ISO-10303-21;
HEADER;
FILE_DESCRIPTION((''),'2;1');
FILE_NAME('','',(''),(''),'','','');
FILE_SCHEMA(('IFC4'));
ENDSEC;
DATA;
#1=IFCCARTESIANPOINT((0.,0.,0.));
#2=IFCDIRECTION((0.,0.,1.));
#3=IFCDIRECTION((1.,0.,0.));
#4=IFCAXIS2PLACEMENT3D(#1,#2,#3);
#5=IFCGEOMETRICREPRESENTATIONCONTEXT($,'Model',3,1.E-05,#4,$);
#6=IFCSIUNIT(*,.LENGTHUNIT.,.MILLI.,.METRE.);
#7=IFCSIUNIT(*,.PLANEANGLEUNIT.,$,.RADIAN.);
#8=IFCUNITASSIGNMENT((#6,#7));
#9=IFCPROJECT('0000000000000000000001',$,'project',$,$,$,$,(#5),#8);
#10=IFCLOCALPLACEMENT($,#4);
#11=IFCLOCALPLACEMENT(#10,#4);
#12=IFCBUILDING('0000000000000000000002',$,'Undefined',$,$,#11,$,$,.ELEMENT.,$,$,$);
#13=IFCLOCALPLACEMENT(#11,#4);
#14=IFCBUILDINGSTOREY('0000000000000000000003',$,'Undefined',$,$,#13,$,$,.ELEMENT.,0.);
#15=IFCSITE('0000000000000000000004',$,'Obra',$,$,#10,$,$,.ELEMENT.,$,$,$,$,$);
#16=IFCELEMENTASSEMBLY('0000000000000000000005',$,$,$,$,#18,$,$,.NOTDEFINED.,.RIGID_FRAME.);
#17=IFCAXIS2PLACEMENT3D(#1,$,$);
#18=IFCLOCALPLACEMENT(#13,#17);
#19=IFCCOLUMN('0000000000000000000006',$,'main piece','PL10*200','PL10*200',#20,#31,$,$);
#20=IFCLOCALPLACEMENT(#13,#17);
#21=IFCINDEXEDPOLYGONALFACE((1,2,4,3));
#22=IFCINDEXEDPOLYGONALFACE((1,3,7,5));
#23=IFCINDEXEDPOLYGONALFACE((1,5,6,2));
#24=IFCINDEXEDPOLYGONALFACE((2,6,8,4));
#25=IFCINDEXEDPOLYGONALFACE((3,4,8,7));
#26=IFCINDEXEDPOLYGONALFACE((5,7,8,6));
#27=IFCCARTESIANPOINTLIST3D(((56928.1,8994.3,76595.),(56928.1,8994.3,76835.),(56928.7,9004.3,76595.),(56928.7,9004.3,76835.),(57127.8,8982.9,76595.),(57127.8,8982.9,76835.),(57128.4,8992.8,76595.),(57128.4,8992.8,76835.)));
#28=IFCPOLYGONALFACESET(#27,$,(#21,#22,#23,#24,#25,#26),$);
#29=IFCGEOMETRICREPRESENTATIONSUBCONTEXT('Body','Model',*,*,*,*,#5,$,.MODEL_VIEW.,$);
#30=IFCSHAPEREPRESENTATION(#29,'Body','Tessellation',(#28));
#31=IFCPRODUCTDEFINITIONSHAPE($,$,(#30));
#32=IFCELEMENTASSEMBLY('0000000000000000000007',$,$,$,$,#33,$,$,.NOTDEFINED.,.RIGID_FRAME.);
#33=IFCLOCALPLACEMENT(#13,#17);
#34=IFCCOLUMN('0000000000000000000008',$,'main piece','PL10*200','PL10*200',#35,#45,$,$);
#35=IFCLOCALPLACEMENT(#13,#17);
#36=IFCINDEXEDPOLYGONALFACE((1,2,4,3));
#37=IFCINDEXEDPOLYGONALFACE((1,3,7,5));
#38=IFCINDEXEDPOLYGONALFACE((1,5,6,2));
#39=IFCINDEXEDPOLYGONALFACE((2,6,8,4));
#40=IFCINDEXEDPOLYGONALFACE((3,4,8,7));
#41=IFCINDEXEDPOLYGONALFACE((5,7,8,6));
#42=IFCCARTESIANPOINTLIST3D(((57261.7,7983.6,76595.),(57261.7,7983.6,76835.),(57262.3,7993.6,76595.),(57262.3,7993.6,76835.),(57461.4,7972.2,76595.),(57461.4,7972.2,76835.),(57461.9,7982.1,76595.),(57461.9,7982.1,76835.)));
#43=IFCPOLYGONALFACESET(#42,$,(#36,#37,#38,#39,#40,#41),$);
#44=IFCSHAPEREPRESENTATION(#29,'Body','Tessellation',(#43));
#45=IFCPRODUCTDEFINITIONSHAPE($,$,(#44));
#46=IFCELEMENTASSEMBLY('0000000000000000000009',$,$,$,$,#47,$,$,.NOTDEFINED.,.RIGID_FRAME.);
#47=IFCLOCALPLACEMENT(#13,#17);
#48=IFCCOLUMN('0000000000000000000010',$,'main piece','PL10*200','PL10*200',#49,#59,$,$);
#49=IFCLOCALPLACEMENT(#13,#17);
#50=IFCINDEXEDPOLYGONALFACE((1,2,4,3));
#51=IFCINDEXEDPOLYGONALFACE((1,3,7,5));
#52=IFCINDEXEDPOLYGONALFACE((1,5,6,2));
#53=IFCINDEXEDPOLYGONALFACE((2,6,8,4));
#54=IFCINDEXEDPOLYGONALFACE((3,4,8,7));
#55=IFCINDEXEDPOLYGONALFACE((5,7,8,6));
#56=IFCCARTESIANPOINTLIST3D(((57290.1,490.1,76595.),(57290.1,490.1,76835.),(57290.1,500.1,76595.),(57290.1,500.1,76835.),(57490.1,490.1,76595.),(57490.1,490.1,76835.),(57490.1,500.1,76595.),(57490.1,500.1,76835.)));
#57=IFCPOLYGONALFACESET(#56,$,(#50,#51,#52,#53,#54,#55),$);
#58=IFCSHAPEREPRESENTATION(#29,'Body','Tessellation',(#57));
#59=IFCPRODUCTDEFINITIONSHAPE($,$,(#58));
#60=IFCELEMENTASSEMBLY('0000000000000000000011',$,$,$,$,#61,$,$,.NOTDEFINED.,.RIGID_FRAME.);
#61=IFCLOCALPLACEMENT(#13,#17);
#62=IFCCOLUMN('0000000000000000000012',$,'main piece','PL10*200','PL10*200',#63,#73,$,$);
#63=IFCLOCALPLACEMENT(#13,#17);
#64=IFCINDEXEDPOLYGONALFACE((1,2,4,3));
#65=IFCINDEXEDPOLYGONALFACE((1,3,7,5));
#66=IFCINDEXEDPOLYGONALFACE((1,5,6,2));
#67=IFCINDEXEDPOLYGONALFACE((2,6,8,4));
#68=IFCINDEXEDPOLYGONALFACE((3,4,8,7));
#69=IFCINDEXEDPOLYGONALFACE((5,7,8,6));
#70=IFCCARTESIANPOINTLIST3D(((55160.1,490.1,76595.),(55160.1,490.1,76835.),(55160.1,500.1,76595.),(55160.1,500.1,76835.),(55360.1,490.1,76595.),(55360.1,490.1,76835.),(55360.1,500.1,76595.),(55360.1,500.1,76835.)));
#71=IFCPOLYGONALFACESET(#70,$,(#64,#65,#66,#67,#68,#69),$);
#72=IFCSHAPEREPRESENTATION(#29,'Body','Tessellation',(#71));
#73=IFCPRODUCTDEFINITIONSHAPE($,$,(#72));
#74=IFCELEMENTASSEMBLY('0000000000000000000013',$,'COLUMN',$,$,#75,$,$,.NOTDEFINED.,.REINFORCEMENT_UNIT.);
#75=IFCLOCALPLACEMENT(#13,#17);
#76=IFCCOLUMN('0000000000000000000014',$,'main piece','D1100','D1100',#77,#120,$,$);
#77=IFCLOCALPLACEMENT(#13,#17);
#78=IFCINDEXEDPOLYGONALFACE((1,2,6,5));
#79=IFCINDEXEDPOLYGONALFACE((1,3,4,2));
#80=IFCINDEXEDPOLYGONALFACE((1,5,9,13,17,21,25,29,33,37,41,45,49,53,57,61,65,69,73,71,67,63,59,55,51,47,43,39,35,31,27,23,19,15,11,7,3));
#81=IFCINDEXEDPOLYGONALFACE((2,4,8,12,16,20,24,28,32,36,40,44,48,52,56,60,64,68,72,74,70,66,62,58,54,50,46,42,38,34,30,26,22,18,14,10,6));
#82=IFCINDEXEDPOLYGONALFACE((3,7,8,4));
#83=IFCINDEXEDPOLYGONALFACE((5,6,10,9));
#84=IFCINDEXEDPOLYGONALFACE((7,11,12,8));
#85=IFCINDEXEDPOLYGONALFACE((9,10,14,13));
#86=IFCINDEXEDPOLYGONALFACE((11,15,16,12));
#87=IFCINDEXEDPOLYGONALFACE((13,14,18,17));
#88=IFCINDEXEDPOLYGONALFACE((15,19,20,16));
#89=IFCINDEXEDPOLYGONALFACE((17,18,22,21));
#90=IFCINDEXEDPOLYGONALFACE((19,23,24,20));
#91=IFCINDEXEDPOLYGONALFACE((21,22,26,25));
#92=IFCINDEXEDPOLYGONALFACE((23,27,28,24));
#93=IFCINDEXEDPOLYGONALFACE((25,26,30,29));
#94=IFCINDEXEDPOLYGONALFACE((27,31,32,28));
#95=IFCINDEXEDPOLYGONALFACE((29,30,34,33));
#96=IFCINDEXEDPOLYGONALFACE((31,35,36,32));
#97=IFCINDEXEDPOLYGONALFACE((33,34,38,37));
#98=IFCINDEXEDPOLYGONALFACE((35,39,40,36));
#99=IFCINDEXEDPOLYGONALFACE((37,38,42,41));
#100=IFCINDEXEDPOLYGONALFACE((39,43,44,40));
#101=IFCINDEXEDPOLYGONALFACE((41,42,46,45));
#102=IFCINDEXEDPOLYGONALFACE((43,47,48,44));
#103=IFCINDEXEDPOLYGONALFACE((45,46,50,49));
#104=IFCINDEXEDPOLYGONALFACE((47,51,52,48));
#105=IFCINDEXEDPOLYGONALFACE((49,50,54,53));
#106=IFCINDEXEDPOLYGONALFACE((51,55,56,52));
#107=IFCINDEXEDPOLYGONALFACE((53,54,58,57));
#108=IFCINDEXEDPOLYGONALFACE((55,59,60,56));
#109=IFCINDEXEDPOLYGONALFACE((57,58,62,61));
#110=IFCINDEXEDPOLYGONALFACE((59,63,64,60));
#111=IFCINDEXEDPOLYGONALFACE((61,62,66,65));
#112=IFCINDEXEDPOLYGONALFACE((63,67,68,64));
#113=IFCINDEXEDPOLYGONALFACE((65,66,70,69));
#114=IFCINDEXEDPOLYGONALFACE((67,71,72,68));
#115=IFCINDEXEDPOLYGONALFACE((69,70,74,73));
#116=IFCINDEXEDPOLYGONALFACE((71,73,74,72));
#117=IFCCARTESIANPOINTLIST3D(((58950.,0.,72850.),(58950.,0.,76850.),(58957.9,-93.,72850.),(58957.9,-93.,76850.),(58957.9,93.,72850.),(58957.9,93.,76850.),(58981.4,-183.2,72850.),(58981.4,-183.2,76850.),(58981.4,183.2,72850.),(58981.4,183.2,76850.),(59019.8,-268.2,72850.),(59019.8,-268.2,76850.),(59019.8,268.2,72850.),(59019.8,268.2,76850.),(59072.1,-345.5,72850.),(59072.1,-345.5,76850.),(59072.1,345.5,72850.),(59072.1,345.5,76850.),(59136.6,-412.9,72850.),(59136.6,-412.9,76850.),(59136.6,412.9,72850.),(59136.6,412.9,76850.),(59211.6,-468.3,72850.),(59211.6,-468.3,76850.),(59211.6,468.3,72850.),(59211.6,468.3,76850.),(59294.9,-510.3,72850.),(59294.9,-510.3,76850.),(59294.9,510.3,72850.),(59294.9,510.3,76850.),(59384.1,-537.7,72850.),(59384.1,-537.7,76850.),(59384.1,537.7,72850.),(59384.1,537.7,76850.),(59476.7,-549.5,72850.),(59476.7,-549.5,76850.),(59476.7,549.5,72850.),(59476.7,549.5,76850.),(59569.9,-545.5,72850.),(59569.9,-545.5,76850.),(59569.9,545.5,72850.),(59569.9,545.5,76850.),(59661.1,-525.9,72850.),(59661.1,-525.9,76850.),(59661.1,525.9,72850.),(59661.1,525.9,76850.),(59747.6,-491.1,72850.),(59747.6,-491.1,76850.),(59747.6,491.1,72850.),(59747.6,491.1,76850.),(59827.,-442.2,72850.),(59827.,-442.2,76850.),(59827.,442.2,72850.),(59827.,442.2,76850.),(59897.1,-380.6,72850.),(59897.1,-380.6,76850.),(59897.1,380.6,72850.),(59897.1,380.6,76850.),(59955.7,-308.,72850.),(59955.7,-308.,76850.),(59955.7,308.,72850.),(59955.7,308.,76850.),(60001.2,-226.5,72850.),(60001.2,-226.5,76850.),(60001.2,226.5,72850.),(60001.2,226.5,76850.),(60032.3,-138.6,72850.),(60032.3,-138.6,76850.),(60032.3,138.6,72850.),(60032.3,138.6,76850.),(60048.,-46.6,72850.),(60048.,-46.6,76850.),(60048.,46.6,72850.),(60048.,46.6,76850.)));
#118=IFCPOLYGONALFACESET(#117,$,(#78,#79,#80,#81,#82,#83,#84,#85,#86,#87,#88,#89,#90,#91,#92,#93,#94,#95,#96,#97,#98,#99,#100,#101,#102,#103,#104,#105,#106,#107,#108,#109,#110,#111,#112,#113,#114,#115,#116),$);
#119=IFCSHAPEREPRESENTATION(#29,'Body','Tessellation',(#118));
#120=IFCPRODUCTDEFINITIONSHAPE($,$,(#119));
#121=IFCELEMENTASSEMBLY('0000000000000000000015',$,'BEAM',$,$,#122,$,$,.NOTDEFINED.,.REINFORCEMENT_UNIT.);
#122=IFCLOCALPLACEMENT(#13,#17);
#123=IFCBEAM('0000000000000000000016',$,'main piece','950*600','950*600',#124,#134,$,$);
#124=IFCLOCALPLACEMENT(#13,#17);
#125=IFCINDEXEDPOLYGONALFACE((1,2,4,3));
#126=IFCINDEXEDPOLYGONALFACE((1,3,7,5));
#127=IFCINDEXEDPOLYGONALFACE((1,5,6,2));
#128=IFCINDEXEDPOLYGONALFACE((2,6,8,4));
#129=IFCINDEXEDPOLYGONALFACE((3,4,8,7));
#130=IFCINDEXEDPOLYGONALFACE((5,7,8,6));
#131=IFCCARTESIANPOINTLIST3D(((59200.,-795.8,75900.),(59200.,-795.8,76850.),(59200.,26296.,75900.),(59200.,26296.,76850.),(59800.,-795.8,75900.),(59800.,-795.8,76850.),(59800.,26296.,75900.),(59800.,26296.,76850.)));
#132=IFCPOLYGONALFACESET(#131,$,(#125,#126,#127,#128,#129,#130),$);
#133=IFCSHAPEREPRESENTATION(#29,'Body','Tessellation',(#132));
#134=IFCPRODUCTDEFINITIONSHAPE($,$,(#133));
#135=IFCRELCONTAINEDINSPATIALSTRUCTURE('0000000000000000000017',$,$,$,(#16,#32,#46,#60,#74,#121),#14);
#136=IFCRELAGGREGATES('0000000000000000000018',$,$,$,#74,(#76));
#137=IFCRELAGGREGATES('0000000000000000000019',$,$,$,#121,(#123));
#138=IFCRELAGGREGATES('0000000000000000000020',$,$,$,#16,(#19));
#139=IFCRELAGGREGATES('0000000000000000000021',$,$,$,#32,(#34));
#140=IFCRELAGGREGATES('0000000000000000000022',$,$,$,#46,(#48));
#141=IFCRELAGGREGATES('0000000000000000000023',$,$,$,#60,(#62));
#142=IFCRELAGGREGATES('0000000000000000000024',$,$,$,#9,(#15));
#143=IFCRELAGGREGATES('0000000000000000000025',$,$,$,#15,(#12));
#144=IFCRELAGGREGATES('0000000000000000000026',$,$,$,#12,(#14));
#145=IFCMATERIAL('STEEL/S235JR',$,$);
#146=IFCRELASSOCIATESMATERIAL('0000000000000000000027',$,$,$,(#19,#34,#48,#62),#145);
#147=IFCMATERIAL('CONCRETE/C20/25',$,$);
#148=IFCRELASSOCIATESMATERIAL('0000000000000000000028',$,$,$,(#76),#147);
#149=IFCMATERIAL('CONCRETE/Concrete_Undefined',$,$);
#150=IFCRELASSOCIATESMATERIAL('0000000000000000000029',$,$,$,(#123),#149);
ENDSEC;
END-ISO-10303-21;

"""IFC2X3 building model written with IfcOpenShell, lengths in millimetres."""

from ifc_helpers import new_model, si_unit, frame, origin_with_axes, origin_2d_with_axis, place, context, subcontext, project, spatial, rectangle, circle, extrude, material, element, aggregate, save


model = new_model("IFC2X3")

# Units and contexts
model_context = context("Model", 3, precision=1e-05, world=origin_with_axes())
body_context = subcontext(model_context, "Body", "Model", "MODEL_VIEW")
ifc_project = project(units=[si_unit("LENGTHUNIT", "METRE", prefix="MILLI"), si_unit("PLANEANGLEUNIT", "RADIAN")], contexts=[model_context])

# Site, building, storey
site_placement = place(None, origin_with_axes())
site = spatial("IfcSite", under=ifc_project, at=site_placement, Name="Obra", CompositionType="ELEMENT")
building_placement = place(site_placement, origin_with_axes())
building = spatial("IfcBuilding", under=site, at=building_placement, Name="Undefined", CompositionType="ELEMENT")
storey_placement = place(building_placement, origin_with_axes())
storey = spatial("IfcBuildingStorey", under=building, at=storey_placement, Name="Undefined", CompositionType="ELEMENT", Elevation=0.0)

# Element assemblies, columns
assembly_1_placement = place(storey_placement, origin_with_axes())
assembly_1 = element("IfcElementAssembly", 1, at=assembly_1_placement, inside=storey, AssemblyPlace="NOTDEFINED", PredefinedType="RIGID_FRAME")
ifc_material_1 = material(Name="STEEL/S235JR")
column_1_placement = place(assembly_1_placement, frame((57028.3, 8993.6, 76595.0), z_axis=(0.0, 0.0, 1.0), x_axis=(0.998368, -0.05711, 0.0)))
column_1 = element("IfcColumn", 2, at=column_1_placement, material=ifc_material_1, Name="main piece", Description="PL10*200", ObjectType="PL10*200", context=body_context, shape_type="SweptSolid", body=[
    extrude(rectangle(XDim=10.0, YDim=200.0, at=origin_2d_with_axis()), frame((0.0, 0.0, 240.0), z_axis=(0.0, 0.0, -1.0), x_axis=(0.0, 1.0, 0.0)), (0.0, 0.0, 1.0), 240.0),
])
assembly_2_placement = place(storey_placement, origin_with_axes())
assembly_2 = element("IfcElementAssembly", 3, at=assembly_2_placement, inside=storey, AssemblyPlace="NOTDEFINED", PredefinedType="RIGID_FRAME")
column_2_placement = place(assembly_2_placement, frame((57361.8, 7982.9, 76595.0), z_axis=(0.0, 0.0, 1.0), x_axis=(-0.998368, 0.05711, 0.0)))
column_2 = element("IfcColumn", 4, at=column_2_placement, material=ifc_material_1, Name="main piece", Description="PL10*200", ObjectType="PL10*200", context=body_context, shape_type="SweptSolid", body=[
    extrude(rectangle(XDim=10.0, YDim=200.0, at=origin_2d_with_axis()), frame((0.0, 0.0, 240.0), z_axis=(0.0, 0.0, -1.0), x_axis=(0.0, 1.0, 0.0)), (0.0, 0.0, 1.0), 240.0),
])
assembly_3_placement = place(storey_placement, origin_with_axes())
assembly_3 = element("IfcElementAssembly", 5, at=assembly_3_placement, inside=storey, AssemblyPlace="NOTDEFINED", PredefinedType="RIGID_FRAME")
column_3_placement = place(assembly_3_placement, frame((57390.1, 495.1, 76595.0), z_axis=(0.0, 0.0, 1.0), x_axis=(1.0, 0.000002, 0.0)))
column_3 = element("IfcColumn", 6, at=column_3_placement, material=ifc_material_1, Name="main piece", Description="PL10*200", ObjectType="PL10*200", context=body_context, shape_type="SweptSolid", body=[
    extrude(rectangle(XDim=10.0, YDim=200.0, at=origin_2d_with_axis()), frame((0.0, 0.0, 240.0), z_axis=(0.0, 0.0, -1.0), x_axis=(0.0, 1.0, 0.0)), (0.0, 0.0, 1.0), 240.0),
])
assembly_4_placement = place(storey_placement, origin_with_axes())
assembly_4 = element("IfcElementAssembly", 7, at=assembly_4_placement, inside=storey, AssemblyPlace="NOTDEFINED", PredefinedType="RIGID_FRAME")
column_4_placement = place(assembly_4_placement, frame((55260.1, 495.1, 76595.0), z_axis=(0.0, 0.0, 1.0), x_axis=(1.0, 0.000002, 0.0)))
column_4 = element("IfcColumn", 8, at=column_4_placement, material=ifc_material_1, Name="main piece", Description="PL10*200", ObjectType="PL10*200", context=body_context, shape_type="SweptSolid", body=[
    extrude(rectangle(XDim=10.0, YDim=200.0, at=origin_2d_with_axis()), frame((0.0, 0.0, 240.0), z_axis=(0.0, 0.0, -1.0), x_axis=(0.0, 1.0, 0.0)), (0.0, 0.0, 1.0), 240.0),
])
assembly_5_placement = place(storey_placement, origin_with_axes())
assembly_5 = element("IfcElementAssembly", 9, at=assembly_5_placement, inside=storey, Name="COLUMN", AssemblyPlace="NOTDEFINED", PredefinedType="REINFORCEMENT_UNIT")
ifc_material_2 = material(Name="CONCRETE/C20/25")
column_5_placement = place(assembly_5_placement, frame((59500.0, 0.0, 72850.0), z_axis=(0.0, 0.0, 1.0), x_axis=(0.0, 1.0, 0.0)))
column_5 = element("IfcColumn", 10, at=column_5_placement, material=ifc_material_2, Name="main piece", Description="D1100", ObjectType="D1100", context=body_context, shape_type="SweptSolid", body=[
    extrude(circle(Radius=550.0, at=origin_2d_with_axis()), frame((0.0, 0.0, 4000.0), z_axis=(0.0, 0.0, -1.0), x_axis=(0.0, 1.0, 0.0)), (0.0, 0.0, 1.0), 4000.0),
])
aggregate(assembly_5, [column_5])

# Element assembly, beam
assembly_6_placement = place(storey_placement, origin_with_axes())
assembly_6 = element("IfcElementAssembly", 11, at=assembly_6_placement, inside=storey, Name="BEAM", AssemblyPlace="NOTDEFINED", PredefinedType="REINFORCEMENT_UNIT")
ifc_material_3 = material(Name="CONCRETE/Concrete_Undefined")
beam_1_placement = place(assembly_6_placement, frame((59500.0, -795.8, 76375.0), z_axis=(0.0, 0.0, 1.0), x_axis=(0.0, 1.0, 0.0)))
beam_1 = element("IfcBeam", 12, at=beam_1_placement, material=ifc_material_3, Name="main piece", Description="950*600", ObjectType="950*600", context=body_context, shape_type="SweptSolid", body=[
    extrude(rectangle(XDim=600.0, YDim=950.0, at=origin_2d_with_axis()), frame((27091.8, 0.0, 0.0), z_axis=(-1.0, 0.0, 0.0), x_axis=(0.0, -1.0, 0.0)), (0.0, 0.0, 1.0), 27091.8),
])
aggregate(assembly_6, [beam_1])

aggregate(assembly_1, [column_1])

aggregate(assembly_2, [column_2])
aggregate(assembly_3, [column_3])
aggregate(assembly_4, [column_4])

save(model, "model.ifc")
